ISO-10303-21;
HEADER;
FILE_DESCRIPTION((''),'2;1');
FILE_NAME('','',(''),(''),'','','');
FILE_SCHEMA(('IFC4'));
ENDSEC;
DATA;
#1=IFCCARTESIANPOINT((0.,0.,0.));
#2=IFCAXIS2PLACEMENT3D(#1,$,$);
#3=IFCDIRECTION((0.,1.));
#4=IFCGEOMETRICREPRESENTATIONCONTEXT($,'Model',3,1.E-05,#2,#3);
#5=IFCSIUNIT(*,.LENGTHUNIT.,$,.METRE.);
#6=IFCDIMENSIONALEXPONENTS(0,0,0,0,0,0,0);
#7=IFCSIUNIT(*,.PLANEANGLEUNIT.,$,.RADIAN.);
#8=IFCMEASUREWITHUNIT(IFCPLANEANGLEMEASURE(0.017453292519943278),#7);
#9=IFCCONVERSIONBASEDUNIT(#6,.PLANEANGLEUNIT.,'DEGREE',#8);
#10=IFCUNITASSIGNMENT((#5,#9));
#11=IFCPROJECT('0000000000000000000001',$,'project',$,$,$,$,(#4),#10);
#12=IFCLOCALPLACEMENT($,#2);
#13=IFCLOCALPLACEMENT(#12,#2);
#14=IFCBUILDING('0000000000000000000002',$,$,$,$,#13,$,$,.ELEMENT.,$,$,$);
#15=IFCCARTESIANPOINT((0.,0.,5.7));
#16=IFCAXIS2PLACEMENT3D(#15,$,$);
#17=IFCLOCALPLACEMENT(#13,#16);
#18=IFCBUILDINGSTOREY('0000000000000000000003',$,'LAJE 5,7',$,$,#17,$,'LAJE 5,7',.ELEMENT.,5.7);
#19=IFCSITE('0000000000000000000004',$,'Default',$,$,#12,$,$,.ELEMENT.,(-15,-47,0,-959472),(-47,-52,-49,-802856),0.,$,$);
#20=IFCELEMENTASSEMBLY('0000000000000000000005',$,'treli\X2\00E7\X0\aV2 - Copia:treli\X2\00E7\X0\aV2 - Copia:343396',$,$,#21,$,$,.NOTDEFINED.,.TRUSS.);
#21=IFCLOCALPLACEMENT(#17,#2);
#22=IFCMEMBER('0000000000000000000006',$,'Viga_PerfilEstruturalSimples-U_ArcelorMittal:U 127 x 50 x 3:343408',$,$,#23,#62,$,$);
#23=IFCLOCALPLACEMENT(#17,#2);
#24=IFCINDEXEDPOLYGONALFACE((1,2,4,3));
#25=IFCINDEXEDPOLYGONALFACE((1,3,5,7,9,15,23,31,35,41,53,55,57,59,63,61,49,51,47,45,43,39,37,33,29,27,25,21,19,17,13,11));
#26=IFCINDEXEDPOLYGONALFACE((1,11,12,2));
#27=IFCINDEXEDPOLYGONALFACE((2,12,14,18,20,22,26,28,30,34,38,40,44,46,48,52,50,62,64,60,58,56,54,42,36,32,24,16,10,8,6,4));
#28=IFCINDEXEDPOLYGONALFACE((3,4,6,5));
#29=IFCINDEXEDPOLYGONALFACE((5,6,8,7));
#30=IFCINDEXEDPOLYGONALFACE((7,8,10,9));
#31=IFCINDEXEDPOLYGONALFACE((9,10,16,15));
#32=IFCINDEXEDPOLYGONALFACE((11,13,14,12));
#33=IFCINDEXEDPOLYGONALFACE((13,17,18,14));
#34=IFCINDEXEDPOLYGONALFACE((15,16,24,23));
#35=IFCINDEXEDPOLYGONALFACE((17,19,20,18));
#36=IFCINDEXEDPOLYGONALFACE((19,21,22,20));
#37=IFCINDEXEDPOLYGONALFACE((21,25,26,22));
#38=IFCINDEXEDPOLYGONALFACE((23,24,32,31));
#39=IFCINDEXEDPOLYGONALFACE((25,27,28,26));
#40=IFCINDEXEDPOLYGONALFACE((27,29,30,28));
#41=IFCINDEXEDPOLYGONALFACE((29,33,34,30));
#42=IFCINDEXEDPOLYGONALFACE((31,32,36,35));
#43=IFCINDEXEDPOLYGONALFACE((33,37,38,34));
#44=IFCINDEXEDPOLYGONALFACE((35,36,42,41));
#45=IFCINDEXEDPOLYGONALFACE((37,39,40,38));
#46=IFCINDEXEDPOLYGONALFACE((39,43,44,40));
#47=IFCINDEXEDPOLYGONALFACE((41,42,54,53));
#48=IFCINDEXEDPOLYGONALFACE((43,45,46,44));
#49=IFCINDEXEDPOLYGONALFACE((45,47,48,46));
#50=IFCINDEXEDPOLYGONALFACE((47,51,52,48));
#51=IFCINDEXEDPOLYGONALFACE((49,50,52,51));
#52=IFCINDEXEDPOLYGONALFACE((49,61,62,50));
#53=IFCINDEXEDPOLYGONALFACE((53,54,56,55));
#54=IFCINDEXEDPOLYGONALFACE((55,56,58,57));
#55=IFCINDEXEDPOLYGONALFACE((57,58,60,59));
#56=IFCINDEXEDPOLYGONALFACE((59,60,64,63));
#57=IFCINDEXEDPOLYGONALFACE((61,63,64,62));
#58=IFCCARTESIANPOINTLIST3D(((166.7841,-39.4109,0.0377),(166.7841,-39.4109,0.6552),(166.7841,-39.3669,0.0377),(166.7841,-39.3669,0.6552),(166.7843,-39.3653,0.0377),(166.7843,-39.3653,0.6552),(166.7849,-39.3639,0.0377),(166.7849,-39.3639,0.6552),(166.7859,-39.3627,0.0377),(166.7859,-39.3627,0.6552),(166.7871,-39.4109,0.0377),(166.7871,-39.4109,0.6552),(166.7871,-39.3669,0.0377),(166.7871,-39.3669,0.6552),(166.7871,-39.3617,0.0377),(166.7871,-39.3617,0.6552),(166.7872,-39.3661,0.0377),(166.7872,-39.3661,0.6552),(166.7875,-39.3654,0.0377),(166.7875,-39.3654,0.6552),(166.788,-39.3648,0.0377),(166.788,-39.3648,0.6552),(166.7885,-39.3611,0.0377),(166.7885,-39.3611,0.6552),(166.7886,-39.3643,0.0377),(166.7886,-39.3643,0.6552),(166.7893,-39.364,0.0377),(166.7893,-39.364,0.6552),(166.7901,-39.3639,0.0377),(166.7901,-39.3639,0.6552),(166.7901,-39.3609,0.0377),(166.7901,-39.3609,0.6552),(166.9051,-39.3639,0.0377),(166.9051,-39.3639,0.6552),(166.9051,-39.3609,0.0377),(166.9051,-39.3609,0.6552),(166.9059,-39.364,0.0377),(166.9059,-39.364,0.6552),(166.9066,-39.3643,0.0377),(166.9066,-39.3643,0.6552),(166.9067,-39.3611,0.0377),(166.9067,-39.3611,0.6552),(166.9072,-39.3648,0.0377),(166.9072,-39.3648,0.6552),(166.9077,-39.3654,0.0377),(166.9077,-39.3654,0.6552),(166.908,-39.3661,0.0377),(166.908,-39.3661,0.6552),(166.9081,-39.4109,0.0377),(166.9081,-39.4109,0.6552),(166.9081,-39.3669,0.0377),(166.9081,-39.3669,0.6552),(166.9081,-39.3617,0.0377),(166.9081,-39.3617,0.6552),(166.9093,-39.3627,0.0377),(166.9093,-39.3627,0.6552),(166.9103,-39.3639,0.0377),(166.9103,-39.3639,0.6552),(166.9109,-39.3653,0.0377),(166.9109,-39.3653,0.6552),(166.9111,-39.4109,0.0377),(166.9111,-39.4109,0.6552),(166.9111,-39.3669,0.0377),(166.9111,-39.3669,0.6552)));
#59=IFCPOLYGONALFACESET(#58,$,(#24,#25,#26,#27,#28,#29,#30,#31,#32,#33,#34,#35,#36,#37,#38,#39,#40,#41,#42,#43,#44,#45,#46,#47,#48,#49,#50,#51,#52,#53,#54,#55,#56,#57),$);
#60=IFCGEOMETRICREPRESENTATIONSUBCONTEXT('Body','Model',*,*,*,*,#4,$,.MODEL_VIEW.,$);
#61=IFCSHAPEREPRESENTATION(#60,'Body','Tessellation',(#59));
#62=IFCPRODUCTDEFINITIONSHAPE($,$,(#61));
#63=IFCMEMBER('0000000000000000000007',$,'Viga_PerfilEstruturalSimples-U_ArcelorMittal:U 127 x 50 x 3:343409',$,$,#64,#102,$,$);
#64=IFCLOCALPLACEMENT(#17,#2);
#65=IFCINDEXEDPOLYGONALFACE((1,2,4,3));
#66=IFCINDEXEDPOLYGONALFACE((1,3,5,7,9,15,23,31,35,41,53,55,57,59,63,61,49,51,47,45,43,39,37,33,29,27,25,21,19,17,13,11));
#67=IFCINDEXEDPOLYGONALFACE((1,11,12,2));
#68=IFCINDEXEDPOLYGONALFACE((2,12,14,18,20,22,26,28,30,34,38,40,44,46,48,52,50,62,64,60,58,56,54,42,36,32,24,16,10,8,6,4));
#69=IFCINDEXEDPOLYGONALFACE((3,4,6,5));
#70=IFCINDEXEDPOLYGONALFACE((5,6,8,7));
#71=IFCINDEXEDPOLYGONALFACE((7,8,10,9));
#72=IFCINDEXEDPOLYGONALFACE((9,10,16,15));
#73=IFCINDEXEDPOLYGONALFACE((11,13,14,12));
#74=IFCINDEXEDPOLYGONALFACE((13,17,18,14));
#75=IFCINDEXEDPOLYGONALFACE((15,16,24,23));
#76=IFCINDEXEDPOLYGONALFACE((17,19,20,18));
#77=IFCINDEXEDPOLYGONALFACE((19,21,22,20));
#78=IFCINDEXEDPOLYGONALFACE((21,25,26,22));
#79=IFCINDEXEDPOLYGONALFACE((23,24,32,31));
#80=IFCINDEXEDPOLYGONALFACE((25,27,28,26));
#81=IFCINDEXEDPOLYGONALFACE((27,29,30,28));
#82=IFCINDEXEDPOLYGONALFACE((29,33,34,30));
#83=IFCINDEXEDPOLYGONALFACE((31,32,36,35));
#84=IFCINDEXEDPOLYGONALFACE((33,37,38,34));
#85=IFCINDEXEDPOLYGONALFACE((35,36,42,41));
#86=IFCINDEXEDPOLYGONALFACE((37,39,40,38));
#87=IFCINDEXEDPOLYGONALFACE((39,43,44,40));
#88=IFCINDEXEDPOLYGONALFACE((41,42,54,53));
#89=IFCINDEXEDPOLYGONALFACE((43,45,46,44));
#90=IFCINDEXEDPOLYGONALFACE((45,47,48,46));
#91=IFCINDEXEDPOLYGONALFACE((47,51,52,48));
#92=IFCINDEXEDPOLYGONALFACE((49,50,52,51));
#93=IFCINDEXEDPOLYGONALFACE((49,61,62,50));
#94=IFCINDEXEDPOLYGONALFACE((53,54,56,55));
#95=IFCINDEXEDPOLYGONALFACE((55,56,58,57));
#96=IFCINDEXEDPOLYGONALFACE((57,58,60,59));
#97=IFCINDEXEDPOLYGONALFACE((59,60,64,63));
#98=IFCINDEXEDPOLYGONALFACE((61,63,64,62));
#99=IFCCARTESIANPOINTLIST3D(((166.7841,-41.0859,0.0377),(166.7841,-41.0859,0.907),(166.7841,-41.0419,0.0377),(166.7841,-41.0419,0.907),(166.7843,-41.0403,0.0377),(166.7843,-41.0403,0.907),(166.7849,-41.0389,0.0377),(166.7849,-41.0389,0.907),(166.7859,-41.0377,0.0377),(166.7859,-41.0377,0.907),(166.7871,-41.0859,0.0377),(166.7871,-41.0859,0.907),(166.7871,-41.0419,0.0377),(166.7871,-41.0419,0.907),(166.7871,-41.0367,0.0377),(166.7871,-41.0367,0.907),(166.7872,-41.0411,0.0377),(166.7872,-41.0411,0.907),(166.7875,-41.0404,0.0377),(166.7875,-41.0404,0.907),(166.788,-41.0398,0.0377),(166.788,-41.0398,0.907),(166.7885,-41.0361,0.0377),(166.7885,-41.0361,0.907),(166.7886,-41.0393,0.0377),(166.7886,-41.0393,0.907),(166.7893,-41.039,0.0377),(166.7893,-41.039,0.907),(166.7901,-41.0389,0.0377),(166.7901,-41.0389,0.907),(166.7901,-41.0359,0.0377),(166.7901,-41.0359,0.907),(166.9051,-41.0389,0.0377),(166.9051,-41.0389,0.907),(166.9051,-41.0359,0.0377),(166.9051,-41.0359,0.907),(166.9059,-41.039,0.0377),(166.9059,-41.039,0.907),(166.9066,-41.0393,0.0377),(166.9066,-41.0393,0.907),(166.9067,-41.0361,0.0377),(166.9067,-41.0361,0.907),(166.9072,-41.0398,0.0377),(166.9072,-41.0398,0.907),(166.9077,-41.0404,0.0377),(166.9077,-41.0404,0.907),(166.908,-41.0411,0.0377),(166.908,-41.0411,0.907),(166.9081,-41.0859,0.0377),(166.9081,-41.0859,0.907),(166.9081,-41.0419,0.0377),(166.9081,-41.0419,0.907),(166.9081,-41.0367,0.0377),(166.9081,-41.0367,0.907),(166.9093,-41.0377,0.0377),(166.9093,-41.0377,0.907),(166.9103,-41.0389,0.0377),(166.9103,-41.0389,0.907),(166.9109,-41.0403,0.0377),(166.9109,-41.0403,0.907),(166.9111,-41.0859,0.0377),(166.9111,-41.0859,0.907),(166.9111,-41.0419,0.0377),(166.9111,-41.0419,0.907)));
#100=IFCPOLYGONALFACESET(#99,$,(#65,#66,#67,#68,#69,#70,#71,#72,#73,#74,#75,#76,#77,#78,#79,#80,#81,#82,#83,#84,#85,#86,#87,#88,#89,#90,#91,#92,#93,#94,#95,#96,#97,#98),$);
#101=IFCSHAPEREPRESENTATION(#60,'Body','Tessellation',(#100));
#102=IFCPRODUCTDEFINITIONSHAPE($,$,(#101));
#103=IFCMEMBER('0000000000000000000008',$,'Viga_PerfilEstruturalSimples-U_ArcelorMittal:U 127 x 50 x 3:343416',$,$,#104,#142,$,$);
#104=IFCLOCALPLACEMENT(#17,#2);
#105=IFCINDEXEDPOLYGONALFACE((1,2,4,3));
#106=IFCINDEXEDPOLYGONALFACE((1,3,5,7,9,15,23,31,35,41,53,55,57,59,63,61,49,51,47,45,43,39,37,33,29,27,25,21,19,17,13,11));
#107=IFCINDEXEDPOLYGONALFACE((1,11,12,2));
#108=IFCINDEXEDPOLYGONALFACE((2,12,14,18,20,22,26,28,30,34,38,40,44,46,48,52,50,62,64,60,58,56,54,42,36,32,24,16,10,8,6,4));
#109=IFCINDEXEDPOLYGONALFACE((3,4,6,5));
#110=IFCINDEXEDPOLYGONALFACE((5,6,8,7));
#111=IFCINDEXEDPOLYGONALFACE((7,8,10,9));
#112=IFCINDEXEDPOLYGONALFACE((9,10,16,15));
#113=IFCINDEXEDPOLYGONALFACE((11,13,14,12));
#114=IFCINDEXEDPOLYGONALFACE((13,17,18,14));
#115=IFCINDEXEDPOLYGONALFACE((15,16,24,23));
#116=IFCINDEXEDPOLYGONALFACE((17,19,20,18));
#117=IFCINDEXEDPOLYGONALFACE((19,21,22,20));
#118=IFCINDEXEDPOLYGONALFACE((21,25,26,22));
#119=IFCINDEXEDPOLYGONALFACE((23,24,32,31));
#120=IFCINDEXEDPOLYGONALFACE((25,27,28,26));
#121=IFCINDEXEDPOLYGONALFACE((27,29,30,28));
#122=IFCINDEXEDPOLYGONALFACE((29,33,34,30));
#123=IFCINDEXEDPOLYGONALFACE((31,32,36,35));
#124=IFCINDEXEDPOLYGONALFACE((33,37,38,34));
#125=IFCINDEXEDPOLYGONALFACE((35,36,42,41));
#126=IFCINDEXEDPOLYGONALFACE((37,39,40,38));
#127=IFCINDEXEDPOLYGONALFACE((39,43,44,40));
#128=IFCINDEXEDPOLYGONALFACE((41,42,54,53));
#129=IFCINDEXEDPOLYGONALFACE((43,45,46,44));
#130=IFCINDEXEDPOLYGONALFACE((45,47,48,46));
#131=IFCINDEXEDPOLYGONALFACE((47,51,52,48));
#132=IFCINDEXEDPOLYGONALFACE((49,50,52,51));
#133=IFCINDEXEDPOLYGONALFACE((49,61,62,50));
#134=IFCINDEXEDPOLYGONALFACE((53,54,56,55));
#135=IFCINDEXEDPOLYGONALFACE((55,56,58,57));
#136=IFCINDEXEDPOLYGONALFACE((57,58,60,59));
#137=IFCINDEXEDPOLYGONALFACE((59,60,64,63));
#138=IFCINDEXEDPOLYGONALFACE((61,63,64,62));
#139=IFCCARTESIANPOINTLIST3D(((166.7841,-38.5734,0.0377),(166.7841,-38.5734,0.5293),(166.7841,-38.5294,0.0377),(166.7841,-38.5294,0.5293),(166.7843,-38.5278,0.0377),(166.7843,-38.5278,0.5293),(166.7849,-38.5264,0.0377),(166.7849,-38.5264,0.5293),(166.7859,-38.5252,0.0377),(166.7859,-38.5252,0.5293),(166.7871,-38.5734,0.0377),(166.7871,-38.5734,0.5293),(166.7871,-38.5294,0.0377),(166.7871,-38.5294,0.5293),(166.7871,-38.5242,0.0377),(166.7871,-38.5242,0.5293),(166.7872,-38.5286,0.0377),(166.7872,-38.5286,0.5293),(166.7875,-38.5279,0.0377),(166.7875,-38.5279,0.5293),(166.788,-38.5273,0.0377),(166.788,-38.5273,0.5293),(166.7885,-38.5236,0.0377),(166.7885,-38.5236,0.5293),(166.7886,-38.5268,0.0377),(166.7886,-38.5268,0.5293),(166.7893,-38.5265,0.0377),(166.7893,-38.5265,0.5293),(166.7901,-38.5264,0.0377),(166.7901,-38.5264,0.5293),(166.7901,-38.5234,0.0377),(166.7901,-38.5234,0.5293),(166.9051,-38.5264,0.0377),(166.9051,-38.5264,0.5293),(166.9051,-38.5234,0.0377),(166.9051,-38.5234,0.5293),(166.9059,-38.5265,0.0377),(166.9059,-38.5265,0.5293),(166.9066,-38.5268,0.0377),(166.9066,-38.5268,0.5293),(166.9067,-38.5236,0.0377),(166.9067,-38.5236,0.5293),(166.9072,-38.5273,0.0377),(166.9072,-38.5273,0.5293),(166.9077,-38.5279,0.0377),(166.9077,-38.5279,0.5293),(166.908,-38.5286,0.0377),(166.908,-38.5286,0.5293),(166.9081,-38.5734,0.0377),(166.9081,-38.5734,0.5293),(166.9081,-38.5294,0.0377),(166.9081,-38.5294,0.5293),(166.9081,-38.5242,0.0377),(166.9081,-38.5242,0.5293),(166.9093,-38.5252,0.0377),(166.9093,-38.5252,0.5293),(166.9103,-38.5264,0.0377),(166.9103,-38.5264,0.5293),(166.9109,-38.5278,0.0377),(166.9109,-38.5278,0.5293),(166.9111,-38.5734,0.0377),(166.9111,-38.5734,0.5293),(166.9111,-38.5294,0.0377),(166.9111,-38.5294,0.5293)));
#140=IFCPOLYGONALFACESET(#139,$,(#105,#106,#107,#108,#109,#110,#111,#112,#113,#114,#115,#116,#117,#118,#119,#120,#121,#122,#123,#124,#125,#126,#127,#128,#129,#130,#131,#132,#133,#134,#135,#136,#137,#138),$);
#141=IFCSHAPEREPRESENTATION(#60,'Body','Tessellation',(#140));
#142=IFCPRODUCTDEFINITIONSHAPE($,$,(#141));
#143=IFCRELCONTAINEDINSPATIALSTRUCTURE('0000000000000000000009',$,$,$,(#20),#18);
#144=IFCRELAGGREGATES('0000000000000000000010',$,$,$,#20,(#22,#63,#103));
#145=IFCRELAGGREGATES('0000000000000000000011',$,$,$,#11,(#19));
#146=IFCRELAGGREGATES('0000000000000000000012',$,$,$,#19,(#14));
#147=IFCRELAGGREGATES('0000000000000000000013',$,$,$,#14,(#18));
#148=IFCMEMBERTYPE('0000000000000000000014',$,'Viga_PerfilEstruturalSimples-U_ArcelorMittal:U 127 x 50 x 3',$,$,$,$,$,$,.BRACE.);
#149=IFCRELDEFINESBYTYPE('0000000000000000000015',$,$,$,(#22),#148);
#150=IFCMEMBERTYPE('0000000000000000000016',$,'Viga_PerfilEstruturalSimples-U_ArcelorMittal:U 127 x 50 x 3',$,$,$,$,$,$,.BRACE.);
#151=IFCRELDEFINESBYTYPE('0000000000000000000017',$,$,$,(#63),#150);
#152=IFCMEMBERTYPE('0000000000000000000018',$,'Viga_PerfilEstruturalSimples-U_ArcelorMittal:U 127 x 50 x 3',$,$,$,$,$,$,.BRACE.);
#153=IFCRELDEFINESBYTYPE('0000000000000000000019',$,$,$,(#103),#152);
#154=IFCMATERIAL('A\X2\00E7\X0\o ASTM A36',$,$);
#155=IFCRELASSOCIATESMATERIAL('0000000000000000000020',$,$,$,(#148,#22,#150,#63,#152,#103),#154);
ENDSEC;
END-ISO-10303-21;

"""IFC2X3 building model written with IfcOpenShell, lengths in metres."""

from ifc_helpers import new_model, entity, si_unit, converted_unit, direction, frame, frame_2d, origin, place, context, subcontext, project, spatial, polyline, circle_curve, parameter, trimmed, segment, composite_curve, outline, extrude, source, transform, mapped, material, type_object, type_shapes, element, aggregate, save


model = new_model("IFC2X3")

# Units and contexts
model_context = context("Model", 3, precision=1e-05, world=origin(), true_north=direction((0.0, 1.0)))
body_context = subcontext(model_context, "Body", "Model", "MODEL_VIEW")
ifc_project = project(units=[si_unit("LENGTHUNIT", "METRE"), converted_unit("PLANEANGLEUNIT", "DEGREE", entity("IfcPlaneAngleMeasure", 0.017453292519943278), si_unit("PLANEANGLEUNIT", "RADIAN"), dimensions=[0, 0, 0, 0, 0, 0, 0])], contexts=[model_context])

# Site, building, storey
site_placement = place(None, origin())
site = spatial("IfcSite", under=ifc_project, at=site_placement, Name="Default", CompositionType="ELEMENT", RefLatitude=(-15, -47, 0, -959472), RefLongitude=(-47, -52, -49, -802856), RefElevation=0.0)
building_placement = place(site_placement, origin())
building = spatial("IfcBuilding", under=site, at=building_placement, CompositionType="ELEMENT")
storey_placement = place(building_placement, frame((0.0, 0.0, 5.7)))
storey = spatial("IfcBuildingStorey", under=building, at=storey_placement, Name="LAJE 5,7", LongName="LAJE 5,7", CompositionType="ELEMENT", Elevation=5.7)

# Element assembly
assembly_1_placement = place(storey_placement, origin())
assembly_1 = element("IfcElementAssembly", 1, at=assembly_1_placement, inside=storey, Name="treliçaV2 - Copia:treliçaV2 - Copia:343396", AssemblyPlace="NOTDEFINED", PredefinedType="TRUSS")
ifc_material = material(Name="Aço ASTM A36")

# Members
member_type_1 = type_object("IfcMemberType", Name="Viga_PerfilEstruturalSimples-U_ArcelorMittal:U 127 x 50 x 3", PredefinedType="BRACE", material=ifc_material)
shared_shape_1 = source(origin(), body_context, "Body", "SweptSolid", [
    extrude(outline(composite_curve([segment(polyline([(-0.0575, -0.0192), (0.0575, -0.0192)]), True, "CONTINUOUS"), segment(trimmed(circle_curve(frame_2d((0.0575, -0.0132), x_axis=(0.0, 1.0)), 0.006), [parameter(180.0)], [parameter(270.0)], True, "PARAMETER"), True, "CONTINUOUS"), segment(polyline([(0.0635, -0.0132), (0.0635, 0.0308)]), True, "CONTINUOUS"), segment(polyline([(0.0635, 0.0308), (0.0605, 0.0308)]), True, "CONTINUOUS"), segment(polyline([(0.0605, 0.0308), (0.0605, -0.0132)]), True, "CONTINUOUS"), segment(trimmed(circle_curve(frame_2d((0.0575, -0.0132), x_axis=(0.0, 1.0)), 0.003), [parameter(180.0)], [parameter(270.0)], True, "PARAMETER"), False, "CONTINUOUS"), segment(polyline([(0.0575, -0.0162), (-0.0575, -0.0162)]), True, "CONTINUOUS"), segment(trimmed(circle_curve(frame_2d((-0.0575, -0.0132), x_axis=(0.0, 1.0)), 0.003), [parameter(90.0)], [parameter(180.0)], True, "PARAMETER"), False, "CONTINUOUS"), segment(polyline([(-0.0605, -0.0132), (-0.0605, 0.0308)]), True, "CONTINUOUS"), segment(polyline([(-0.0605, 0.0308), (-0.0635, 0.0308)]), True, "CONTINUOUS"), segment(polyline([(-0.0635, 0.0308), (-0.0635, -0.0132)]), True, "CONTINUOUS"), segment(trimmed(circle_curve(frame_2d((-0.0575, -0.0132), x_axis=(0.0, 1.0)), 0.006), [parameter(90.0)], [parameter(180.0)], True, "PARAMETER"), True, "CONTINUOUS")], self_intersect=False)), frame((-0.3108, -0.0058, 0.0), z_axis=(1.0, 0.0, 0.0), x_axis=(0.0, 0.0, -1.0)), (0.0, 0.0, 1.0), 0.6175),
])
type_shapes(member_type_1, [shared_shape_1])
member_1_placement = place(assembly_1_placement, frame((166.8476, -39.3859, 0.3485), z_axis=(1.0, 0.0, 0.0), x_axis=(0.0, 0.0, 1.0)))
member_1 = element("IfcMember", 2, at=member_1_placement, type_object=member_type_1, material=ifc_material, Name="Viga_PerfilEstruturalSimples-U_ArcelorMittal:U 127 x 50 x 3:343408", context=body_context, shape_type="MappedRepresentation", body=[
    mapped(shared_shape_1, transform((0.0, 0.0, 0.0), scale=1.0)),
])
member_type_2 = type_object("IfcMemberType", Name="Viga_PerfilEstruturalSimples-U_ArcelorMittal:U 127 x 50 x 3", PredefinedType="BRACE", material=ifc_material)
shared_shape_2 = source(origin(), body_context, "Body", "SweptSolid", [
    extrude(outline(composite_curve([segment(polyline([(-0.0575, -0.0192), (0.0575, -0.0192)]), True, "CONTINUOUS"), segment(trimmed(circle_curve(frame_2d((0.0575, -0.0132), x_axis=(0.0, 1.0)), 0.006), [parameter(180.0)], [parameter(270.0)], True, "PARAMETER"), True, "CONTINUOUS"), segment(polyline([(0.0635, -0.0132), (0.0635, 0.0308)]), True, "CONTINUOUS"), segment(polyline([(0.0635, 0.0308), (0.0605, 0.0308)]), True, "CONTINUOUS"), segment(polyline([(0.0605, 0.0308), (0.0605, -0.0132)]), True, "CONTINUOUS"), segment(trimmed(circle_curve(frame_2d((0.0575, -0.0132), x_axis=(0.0, 1.0)), 0.003), [parameter(180.0)], [parameter(270.0)], True, "PARAMETER"), False, "CONTINUOUS"), segment(polyline([(0.0575, -0.0162), (-0.0575, -0.0162)]), True, "CONTINUOUS"), segment(trimmed(circle_curve(frame_2d((-0.0575, -0.0132), x_axis=(0.0, 1.0)), 0.003), [parameter(90.0)], [parameter(180.0)], True, "PARAMETER"), False, "CONTINUOUS"), segment(polyline([(-0.0605, -0.0132), (-0.0605, 0.0308)]), True, "CONTINUOUS"), segment(polyline([(-0.0605, 0.0308), (-0.0635, 0.0308)]), True, "CONTINUOUS"), segment(polyline([(-0.0635, 0.0308), (-0.0635, -0.0132)]), True, "CONTINUOUS"), segment(trimmed(circle_curve(frame_2d((-0.0575, -0.0132), x_axis=(0.0, 1.0)), 0.006), [parameter(90.0)], [parameter(180.0)], True, "PARAMETER"), True, "CONTINUOUS")], self_intersect=False)), frame((-0.4367, -0.0058, 0.0), z_axis=(1.0, 0.0, 0.0), x_axis=(0.0, 0.0, -1.0)), (0.0, 0.0, 1.0), 0.8693),
])
type_shapes(member_type_2, [shared_shape_2])
member_2_placement = place(assembly_1_placement, frame((166.8476, -41.0609, 0.4744), z_axis=(1.0, 0.0, 0.0), x_axis=(0.0, 0.0, 1.0)))
member_2 = element("IfcMember", 3, at=member_2_placement, type_object=member_type_2, material=ifc_material, Name="Viga_PerfilEstruturalSimples-U_ArcelorMittal:U 127 x 50 x 3:343409", context=body_context, shape_type="MappedRepresentation", body=[
    mapped(shared_shape_2, transform((0.0, 0.0, 0.0), scale=1.0)),
])
member_type_3 = type_object("IfcMemberType", Name="Viga_PerfilEstruturalSimples-U_ArcelorMittal:U 127 x 50 x 3", PredefinedType="BRACE", material=ifc_material)
shared_shape_3 = source(origin(), body_context, "Body", "SweptSolid", [
    extrude(outline(composite_curve([segment(polyline([(-0.0575, -0.0192), (0.0575, -0.0192)]), True, "CONTINUOUS"), segment(trimmed(circle_curve(frame_2d((0.0575, -0.0132), x_axis=(0.0, 1.0)), 0.006), [parameter(180.0)], [parameter(270.0)], True, "PARAMETER"), True, "CONTINUOUS"), segment(polyline([(0.0635, -0.0132), (0.0635, 0.0308)]), True, "CONTINUOUS"), segment(polyline([(0.0635, 0.0308), (0.0605, 0.0308)]), True, "CONTINUOUS"), segment(polyline([(0.0605, 0.0308), (0.0605, -0.0132)]), True, "CONTINUOUS"), segment(trimmed(circle_curve(frame_2d((0.0575, -0.0132), x_axis=(0.0, 1.0)), 0.003), [parameter(180.0)], [parameter(270.0)], True, "PARAMETER"), False, "CONTINUOUS"), segment(polyline([(0.0575, -0.0162), (-0.0575, -0.0162)]), True, "CONTINUOUS"), segment(trimmed(circle_curve(frame_2d((-0.0575, -0.0132), x_axis=(0.0, 1.0)), 0.003), [parameter(90.0)], [parameter(180.0)], True, "PARAMETER"), False, "CONTINUOUS"), segment(polyline([(-0.0605, -0.0132), (-0.0605, 0.0308)]), True, "CONTINUOUS"), segment(polyline([(-0.0605, 0.0308), (-0.0635, 0.0308)]), True, "CONTINUOUS"), segment(polyline([(-0.0635, 0.0308), (-0.0635, -0.0132)]), True, "CONTINUOUS"), segment(trimmed(circle_curve(frame_2d((-0.0575, -0.0132), x_axis=(0.0, 1.0)), 0.006), [parameter(90.0)], [parameter(180.0)], True, "PARAMETER"), True, "CONTINUOUS")], self_intersect=False)), frame((-0.2478, -0.0058, 0.0), z_axis=(1.0, 0.0, 0.0), x_axis=(0.0, 0.0, -1.0)), (0.0, 0.0, 1.0), 0.4916),
])
type_shapes(member_type_3, [shared_shape_3])
member_3_placement = place(assembly_1_placement, frame((166.8476, -38.5484, 0.2855), z_axis=(1.0, 0.0, 0.0), x_axis=(0.0, 0.0, 1.0)))
member_3 = element("IfcMember", 4, at=member_3_placement, type_object=member_type_3, material=ifc_material, Name="Viga_PerfilEstruturalSimples-U_ArcelorMittal:U 127 x 50 x 3:343416", context=body_context, shape_type="MappedRepresentation", body=[
    mapped(shared_shape_3, transform((0.0, 0.0, 0.0), scale=1.0)),
])

aggregate(assembly_1, [member_1, member_2, member_3])

save(model, "model.ifc")
